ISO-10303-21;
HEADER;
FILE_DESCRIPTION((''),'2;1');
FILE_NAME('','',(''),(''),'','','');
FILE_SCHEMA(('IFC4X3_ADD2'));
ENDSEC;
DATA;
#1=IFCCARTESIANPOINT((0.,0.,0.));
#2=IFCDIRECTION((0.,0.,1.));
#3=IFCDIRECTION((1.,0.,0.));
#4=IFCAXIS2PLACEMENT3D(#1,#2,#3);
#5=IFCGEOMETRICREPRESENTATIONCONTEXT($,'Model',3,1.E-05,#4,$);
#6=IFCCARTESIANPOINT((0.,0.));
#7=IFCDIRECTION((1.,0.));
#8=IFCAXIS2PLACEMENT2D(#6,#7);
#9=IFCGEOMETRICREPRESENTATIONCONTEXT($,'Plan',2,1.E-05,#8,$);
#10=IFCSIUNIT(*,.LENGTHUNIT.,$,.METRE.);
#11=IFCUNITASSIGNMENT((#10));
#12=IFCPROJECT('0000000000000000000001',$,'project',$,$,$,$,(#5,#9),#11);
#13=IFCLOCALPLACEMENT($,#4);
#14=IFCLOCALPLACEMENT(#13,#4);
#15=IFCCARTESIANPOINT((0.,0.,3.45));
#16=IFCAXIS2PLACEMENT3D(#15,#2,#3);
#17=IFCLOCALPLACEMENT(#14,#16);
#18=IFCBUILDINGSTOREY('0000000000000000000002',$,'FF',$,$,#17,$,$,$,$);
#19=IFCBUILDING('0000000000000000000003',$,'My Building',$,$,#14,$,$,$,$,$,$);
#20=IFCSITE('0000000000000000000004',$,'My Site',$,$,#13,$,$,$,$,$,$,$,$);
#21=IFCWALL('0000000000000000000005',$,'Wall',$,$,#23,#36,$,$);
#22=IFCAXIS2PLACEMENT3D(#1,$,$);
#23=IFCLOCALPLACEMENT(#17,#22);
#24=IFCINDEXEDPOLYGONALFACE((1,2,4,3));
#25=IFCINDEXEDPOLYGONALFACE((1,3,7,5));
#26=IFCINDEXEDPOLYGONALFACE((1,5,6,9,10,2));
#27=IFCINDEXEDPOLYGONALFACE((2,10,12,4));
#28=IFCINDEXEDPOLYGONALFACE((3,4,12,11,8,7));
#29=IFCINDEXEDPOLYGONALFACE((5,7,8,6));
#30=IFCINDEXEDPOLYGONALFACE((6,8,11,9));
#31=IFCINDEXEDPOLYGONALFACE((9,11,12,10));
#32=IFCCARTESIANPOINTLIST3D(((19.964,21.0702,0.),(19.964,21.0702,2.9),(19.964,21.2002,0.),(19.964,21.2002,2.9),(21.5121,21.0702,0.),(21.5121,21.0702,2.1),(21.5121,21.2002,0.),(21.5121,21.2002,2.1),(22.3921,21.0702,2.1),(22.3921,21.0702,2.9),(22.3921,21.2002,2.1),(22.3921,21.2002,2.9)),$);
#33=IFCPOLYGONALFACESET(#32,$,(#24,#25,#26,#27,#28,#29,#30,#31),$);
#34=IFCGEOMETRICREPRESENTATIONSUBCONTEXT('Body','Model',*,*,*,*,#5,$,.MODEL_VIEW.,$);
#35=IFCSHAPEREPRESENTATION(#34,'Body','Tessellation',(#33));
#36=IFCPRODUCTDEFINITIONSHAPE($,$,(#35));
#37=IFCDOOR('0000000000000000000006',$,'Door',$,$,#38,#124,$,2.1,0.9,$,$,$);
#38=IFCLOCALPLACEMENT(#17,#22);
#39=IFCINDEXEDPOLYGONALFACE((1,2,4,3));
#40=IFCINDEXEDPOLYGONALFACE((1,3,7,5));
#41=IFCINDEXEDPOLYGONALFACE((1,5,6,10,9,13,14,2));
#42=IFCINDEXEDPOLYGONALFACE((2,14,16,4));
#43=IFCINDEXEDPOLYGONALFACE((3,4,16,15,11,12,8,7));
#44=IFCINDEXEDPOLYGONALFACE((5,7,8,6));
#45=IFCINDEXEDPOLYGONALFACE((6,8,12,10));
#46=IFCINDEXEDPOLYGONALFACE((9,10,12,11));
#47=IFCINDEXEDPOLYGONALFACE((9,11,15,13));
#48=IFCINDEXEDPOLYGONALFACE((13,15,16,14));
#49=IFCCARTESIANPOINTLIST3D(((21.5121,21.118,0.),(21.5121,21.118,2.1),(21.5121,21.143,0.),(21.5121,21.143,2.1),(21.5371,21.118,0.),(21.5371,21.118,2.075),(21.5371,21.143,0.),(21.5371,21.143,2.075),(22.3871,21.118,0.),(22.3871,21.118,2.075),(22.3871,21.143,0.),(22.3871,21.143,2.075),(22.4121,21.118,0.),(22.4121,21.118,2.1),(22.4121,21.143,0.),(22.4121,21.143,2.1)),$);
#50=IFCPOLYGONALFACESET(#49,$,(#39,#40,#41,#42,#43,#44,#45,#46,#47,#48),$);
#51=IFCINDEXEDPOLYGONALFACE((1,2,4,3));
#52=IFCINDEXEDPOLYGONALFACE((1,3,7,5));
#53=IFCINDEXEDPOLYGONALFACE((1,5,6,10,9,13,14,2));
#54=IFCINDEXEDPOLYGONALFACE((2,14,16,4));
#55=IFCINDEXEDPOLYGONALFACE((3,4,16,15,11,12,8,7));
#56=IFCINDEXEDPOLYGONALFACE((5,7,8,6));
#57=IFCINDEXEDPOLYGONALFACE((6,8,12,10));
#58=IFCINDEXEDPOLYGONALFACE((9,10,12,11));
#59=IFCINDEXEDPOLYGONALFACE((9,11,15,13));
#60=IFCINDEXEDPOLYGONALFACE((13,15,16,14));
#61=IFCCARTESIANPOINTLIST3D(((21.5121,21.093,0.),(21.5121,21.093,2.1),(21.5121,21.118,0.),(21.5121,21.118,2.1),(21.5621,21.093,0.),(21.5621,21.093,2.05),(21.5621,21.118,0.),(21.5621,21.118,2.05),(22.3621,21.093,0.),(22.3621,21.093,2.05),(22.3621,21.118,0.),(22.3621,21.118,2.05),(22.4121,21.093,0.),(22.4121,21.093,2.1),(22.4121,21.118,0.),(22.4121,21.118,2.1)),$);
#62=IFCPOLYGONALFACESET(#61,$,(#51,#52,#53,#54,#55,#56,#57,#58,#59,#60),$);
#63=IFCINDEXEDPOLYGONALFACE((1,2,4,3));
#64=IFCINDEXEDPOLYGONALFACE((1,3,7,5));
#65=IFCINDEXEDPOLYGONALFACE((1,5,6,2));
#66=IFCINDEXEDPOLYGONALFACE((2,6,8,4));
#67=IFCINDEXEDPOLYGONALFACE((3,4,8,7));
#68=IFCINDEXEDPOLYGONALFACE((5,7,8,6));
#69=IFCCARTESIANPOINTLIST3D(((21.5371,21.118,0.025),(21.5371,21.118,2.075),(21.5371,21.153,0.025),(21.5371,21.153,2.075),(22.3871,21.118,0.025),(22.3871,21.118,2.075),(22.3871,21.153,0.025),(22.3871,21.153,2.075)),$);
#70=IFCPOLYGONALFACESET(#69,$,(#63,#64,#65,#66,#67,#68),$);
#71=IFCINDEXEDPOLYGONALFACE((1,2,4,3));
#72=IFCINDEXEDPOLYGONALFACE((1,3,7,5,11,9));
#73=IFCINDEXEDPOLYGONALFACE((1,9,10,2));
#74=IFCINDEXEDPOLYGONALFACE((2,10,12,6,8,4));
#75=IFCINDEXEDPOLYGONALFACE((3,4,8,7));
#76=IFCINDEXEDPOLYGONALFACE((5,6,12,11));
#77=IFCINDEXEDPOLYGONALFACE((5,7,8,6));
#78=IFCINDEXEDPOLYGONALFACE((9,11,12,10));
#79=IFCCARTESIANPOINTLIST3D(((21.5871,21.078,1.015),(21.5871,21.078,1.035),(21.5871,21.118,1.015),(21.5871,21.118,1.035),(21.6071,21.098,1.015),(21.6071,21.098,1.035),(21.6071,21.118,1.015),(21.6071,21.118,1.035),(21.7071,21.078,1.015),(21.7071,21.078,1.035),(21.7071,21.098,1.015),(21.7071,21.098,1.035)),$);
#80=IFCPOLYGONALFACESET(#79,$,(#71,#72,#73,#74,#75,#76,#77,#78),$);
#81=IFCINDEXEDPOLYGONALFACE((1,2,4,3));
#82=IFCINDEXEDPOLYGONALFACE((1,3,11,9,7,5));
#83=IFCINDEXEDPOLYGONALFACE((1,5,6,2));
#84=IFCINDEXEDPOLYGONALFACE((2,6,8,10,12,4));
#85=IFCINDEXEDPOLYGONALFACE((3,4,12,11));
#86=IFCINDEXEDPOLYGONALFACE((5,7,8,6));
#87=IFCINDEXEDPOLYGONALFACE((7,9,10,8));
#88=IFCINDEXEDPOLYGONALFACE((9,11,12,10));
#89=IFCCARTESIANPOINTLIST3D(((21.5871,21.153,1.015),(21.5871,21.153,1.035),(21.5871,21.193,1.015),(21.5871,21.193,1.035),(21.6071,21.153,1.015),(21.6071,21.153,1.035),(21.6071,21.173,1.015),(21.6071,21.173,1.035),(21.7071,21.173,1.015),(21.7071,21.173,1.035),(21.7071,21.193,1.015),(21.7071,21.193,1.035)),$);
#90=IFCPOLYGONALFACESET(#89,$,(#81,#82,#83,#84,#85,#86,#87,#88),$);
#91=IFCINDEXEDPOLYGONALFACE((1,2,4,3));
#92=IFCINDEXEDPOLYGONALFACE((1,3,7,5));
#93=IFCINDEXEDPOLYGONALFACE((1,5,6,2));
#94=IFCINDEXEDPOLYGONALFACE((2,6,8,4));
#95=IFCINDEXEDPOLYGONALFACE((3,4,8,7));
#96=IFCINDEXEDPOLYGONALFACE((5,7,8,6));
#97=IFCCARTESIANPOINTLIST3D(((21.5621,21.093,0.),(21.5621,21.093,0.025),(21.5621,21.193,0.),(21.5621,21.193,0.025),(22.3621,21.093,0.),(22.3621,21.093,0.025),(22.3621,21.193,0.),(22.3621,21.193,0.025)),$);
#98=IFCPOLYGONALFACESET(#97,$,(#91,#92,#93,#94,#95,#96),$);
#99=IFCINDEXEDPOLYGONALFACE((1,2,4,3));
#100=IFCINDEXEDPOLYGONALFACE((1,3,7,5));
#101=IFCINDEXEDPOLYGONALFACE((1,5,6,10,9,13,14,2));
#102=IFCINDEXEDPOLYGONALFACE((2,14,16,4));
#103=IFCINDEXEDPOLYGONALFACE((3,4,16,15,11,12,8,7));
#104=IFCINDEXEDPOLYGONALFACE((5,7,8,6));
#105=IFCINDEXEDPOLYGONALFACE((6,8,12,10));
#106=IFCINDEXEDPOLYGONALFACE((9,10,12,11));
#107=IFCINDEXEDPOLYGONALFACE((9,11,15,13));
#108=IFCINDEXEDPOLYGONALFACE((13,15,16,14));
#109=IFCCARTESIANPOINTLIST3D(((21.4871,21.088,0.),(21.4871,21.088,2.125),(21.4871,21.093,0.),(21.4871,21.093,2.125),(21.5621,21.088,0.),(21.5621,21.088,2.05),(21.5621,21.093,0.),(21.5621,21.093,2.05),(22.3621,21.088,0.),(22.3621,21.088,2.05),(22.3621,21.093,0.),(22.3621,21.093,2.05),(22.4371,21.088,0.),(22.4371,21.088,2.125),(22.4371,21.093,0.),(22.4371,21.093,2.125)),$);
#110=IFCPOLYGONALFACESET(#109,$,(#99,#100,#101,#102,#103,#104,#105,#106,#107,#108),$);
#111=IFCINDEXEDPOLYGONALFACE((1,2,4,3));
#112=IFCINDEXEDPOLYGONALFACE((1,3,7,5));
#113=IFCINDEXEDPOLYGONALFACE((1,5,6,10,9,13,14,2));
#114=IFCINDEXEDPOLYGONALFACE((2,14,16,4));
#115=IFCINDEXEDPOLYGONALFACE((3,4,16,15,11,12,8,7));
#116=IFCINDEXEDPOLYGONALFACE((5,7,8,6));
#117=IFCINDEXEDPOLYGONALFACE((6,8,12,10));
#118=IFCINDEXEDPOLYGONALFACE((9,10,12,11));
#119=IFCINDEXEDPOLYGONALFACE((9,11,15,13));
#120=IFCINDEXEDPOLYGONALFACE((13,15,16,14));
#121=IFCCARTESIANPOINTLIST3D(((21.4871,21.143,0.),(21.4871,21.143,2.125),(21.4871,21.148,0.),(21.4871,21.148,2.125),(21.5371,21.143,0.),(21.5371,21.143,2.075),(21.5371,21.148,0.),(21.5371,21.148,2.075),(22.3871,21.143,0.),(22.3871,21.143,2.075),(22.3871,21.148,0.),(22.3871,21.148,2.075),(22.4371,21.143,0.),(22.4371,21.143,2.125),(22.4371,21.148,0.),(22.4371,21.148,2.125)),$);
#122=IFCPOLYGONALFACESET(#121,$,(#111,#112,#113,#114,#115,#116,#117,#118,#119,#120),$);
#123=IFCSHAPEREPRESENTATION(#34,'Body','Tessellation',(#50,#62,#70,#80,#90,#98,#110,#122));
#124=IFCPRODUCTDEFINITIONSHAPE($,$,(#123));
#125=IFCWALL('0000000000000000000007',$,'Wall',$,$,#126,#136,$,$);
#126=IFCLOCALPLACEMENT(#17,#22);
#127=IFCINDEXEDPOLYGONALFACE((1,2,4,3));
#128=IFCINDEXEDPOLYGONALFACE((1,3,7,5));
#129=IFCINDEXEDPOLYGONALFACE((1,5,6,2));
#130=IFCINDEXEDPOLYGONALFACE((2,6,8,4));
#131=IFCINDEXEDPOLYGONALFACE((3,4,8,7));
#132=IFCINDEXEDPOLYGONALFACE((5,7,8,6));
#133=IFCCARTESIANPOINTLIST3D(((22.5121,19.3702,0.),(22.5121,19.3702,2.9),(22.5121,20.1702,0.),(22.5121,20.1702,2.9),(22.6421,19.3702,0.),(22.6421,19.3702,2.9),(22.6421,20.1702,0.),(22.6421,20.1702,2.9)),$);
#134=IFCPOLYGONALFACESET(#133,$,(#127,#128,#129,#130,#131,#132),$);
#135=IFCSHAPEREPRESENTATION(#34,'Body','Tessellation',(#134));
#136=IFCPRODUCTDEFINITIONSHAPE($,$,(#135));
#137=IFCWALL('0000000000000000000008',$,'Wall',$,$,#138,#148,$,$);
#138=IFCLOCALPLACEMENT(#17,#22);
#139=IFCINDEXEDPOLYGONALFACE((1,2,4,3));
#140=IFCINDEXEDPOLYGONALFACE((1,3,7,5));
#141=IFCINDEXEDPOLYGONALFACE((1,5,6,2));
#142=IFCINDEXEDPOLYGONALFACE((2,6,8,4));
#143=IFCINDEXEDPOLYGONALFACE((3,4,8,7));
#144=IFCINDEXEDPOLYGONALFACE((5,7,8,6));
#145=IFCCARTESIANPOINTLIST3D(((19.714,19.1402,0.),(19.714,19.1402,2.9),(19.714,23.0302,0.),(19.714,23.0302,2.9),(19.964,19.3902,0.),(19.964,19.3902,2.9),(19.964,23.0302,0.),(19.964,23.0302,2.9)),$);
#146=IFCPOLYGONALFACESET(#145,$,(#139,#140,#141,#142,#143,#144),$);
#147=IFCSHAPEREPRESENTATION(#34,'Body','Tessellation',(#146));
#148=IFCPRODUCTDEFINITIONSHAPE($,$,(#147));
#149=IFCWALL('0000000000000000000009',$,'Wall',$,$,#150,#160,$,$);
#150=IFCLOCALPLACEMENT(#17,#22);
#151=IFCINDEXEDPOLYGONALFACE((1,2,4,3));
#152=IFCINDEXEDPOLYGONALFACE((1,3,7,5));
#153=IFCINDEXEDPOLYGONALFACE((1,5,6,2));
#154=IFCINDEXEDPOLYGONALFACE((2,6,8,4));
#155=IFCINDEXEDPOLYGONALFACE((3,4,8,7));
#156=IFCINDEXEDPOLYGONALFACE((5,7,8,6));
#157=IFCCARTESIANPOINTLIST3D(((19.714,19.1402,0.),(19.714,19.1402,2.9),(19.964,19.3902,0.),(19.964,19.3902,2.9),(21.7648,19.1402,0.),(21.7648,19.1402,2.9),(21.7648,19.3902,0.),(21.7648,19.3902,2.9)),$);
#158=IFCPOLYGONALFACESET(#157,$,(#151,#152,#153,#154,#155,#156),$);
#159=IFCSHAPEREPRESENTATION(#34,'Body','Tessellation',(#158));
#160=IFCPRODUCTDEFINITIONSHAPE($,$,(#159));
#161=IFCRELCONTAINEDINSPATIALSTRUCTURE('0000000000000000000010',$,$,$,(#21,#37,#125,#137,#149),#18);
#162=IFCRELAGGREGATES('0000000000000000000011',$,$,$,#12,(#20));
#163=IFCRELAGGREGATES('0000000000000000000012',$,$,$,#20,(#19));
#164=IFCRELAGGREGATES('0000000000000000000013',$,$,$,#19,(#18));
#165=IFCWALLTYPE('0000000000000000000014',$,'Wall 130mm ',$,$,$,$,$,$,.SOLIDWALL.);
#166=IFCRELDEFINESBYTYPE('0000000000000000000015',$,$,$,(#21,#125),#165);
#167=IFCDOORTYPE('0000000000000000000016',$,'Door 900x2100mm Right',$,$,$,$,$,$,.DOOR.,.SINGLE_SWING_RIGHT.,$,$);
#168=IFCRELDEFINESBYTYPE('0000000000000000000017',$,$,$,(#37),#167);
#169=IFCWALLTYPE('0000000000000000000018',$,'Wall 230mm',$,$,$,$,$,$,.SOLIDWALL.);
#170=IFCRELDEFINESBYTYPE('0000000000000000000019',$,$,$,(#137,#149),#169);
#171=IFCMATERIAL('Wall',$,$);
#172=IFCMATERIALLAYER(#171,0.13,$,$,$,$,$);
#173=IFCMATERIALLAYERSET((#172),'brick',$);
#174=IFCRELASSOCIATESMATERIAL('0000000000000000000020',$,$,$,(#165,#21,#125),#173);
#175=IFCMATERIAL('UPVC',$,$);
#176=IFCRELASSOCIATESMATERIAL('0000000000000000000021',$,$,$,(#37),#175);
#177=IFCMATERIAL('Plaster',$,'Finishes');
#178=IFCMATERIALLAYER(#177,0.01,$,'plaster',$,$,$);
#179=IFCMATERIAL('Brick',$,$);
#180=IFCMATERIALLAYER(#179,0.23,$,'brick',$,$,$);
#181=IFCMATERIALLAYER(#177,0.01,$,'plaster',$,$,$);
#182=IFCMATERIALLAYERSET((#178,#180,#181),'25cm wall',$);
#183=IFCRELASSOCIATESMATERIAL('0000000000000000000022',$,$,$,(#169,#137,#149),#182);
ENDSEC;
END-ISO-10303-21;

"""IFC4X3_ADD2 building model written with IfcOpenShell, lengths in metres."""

from ifc_helpers import new_model, entity, si_unit, frame, origin_with_axes, origin_2d_with_axis, place, context, subcontext, project, spatial, line, indexed_curve, outline, extrude, shape, source, transform, mapped, material, layer, layer_set, layer_usage, type_object, type_shapes, element, fill, save


model = new_model("IFC4X3_ADD2")

# Units and contexts
model_context = context("Model", 3, precision=1e-05, world=origin_with_axes())
plan_context = context("Plan", 2, precision=1e-05, world=origin_2d_with_axis())
body_context_1 = subcontext(model_context, "Body", "Model", "MODEL_VIEW")
body_context_2 = subcontext(plan_context, "Body", "Plan", "PLAN_VIEW")
ifc_project = project(units=[si_unit("LENGTHUNIT", "METRE")], contexts=[model_context, plan_context])

# Site, building, storey
site_placement = place(None, origin_with_axes())
site = spatial("IfcSite", under=ifc_project, at=site_placement, Name="My Site")
building_placement = place(site_placement, origin_with_axes())
building = spatial("IfcBuilding", under=site, at=building_placement, Name="My Building")
storey_placement = place(building_placement, frame((0.0, 0.0, 3.45), z_axis=(0.0, 0.0, 1.0), x_axis=(1.0, 0.0, 0.0)))
storey = spatial("IfcBuildingStorey", under=building, at=storey_placement, Name="FF")

# Shared definitions
ifc_material_1 = material(Name="UPVC")

# Wall, opening, door
ifc_material_2 = material(Name="Wall")
ifc_layer_1 = layer(ifc_material_2, 0.13)
ifc_layer_set_1 = layer_set([ifc_layer_1], Name="brick")
ifc_layer_usage_1 = layer_usage(ifc_layer_set_1, "AXIS2", "POSITIVE", 0.0)
wall_type_1 = type_object("IfcWallType", Name="Wall 130mm ", PredefinedType="SOLIDWALL", material=ifc_layer_set_1)
wall_1_placement = place(storey_placement, frame((22.6421, 21.2002, 0.0), z_axis=(0.0, 0.0, 1.0), x_axis=(-1.0, 0.0, 0.0)))
wall_1 = element("IfcWall", 1, at=wall_1_placement, inside=storey, type_object=wall_type_1, material=ifc_layer_usage_1, Name="Wall", context=body_context_1, shape_type="SweptSolid", body=[
    extrude(outline(indexed_curve([(0.25, 0.0), (0.25, 0.13), (2.6781, 0.13), (2.6781, 0.0)], segments=[line(1, 2, 3, 4, 1)])), origin_with_axes(), (0.0, 0.0, 1.0), 2.9),
])
shared_shape_1 = source(origin_with_axes(), body_context_1, "Body", "SweptSolid", [
    extrude(outline(indexed_curve([(0.0, 0.0), (0.9, 0.0), (0.9, 2.1), (0.0, 2.1)], segments=[line(1, 2, 3, 4, 1)])), frame((0.0, -0.6, 0.0), z_axis=(0.0, -1.0, 0.0), x_axis=(1.0, 0.0, 0.0)), (0.0, 0.0, -1.0), 1.2),
])
opening_placement = place(wall_1_placement, frame((1.13, 0.1072, 0.0), z_axis=(0.0, 0.0, 1.0), x_axis=(-1.0, 0.0, 0.0)))
opening = element("IfcOpeningElement", 2, at=opening_placement, cuts=wall_1, PredefinedType="OPENING", context=body_context_1, shape_type="MappedRepresentation", body=[
    mapped(shared_shape_1, transform((0.0, 0.0, 0.0), x_axis=(1.0, 0.0, 0.0), y_axis=(0.0, 1.0, 0.0), z_axis=(0.0, 0.0, 1.0), scale=1.0)),
])
door_type = type_object("IfcDoorType", Name="Door 900x2100mm Right", OperationType="SINGLE_SWING_RIGHT", PredefinedType="DOOR")
shared_shape_2 = source(origin_with_axes(), body_context_1, "Body", "SweptSolid", [
    extrude(outline(indexed_curve([(0.0, 0.0), (0.0, 2.1), (0.9, 2.1), (0.9, 0.0), (0.875, 0.0), (0.875, 2.075), (0.025, 2.075), (0.025, 0.0)], segments=[line(1, 2, 3, 4, 5, 6, 7, 8, 1)])), frame((0.0, 0.025, 0.0), z_axis=(0.0, -1.0, 0.0), x_axis=(1.0, 0.0, 0.0)), (0.0, 0.0, -1.0), 0.025),
    extrude(outline(indexed_curve([(0.0, 0.0), (0.0, 2.1), (0.9, 2.1), (0.9, 0.0), (0.85, 0.0), (0.85, 2.05), (0.05, 2.05), (0.05, 0.0)], segments=[line(1, 2, 3, 4, 5, 6, 7, 8, 1)])), frame((0.0, 0.0, 0.0), z_axis=(0.0, -1.0, 0.0), x_axis=(1.0, 0.0, 0.0)), (0.0, 0.0, -1.0), 0.025),
    extrude(outline(indexed_curve([(0.0, 0.0), (0.85, 0.0), (0.85, 0.035), (0.0, 0.035)], segments=[line(1, 2, 3, 4, 1)])), frame((0.025, 0.025, 0.025), z_axis=(0.0, 0.0, 1.0), x_axis=(1.0, 0.0, 0.0)), (0.0, 0.0, 1.0), 2.05),
    extrude(outline(indexed_curve([(0.0, 0.0), (0.0, -0.04), (0.12, -0.04), (0.12, -0.02), (0.02, -0.02), (0.02, 0.0)], segments=[line(1, 2, 3, 4, 5, 6, 1)])), frame((0.075, 0.025, 1.015), z_axis=(0.0, 0.0, 1.0), x_axis=(1.0, 0.0, 0.0)), (0.0, 0.0, 1.0), 0.02),
    extrude(outline(indexed_curve([(0.0, 0.0), (0.0, 0.04), (0.12, 0.04), (0.12, 0.02), (0.02, 0.02), (0.02, 0.0)], segments=[line(1, 2, 3, 4, 5, 6, 1)])), frame((0.075, 0.06, 1.015), z_axis=(0.0, 0.0, 1.0), x_axis=(1.0, 0.0, 0.0)), (0.0, 0.0, 1.0), 0.02),
    extrude(outline(indexed_curve([(0.0, 0.0), (0.8, 0.0), (0.8, 0.1), (0.0, 0.1)], segments=[line(1, 2, 3, 4, 1)])), frame((0.05, 0.0, 0.0), z_axis=(0.0, 0.0, 1.0), x_axis=(1.0, 0.0, 0.0)), (0.0, 0.0, 1.0), 0.025),
    extrude(outline(indexed_curve([(0.0, 0.0), (0.0, 2.125), (0.95, 2.125), (0.95, 0.0), (0.875, 0.0), (0.875, 2.05), (0.075, 2.05), (0.075, 0.0)], segments=[line(1, 2, 3, 4, 5, 6, 7, 8, 1)])), frame((-0.025, -0.005, 0.0), z_axis=(0.0, -1.0, 0.0), x_axis=(1.0, 0.0, 0.0)), (0.0, 0.0, -1.0), 0.005),
    extrude(outline(indexed_curve([(0.0, 0.0), (0.0, 2.125), (0.95, 2.125), (0.95, 0.0), (0.9, 0.0), (0.9, 2.075), (0.05, 2.075), (0.05, 0.0)], segments=[line(1, 2, 3, 4, 5, 6, 7, 8, 1)])), frame((-0.025, 0.05, 0.0), z_axis=(0.0, -1.0, 0.0), x_axis=(1.0, 0.0, 0.0)), (0.0, 0.0, -1.0), 0.005),
])
shared_shape_3 = source(origin_with_axes(), body_context_2, "Body", "Curve2D", [
    entity("IfcIndexedPolyCurve", entity("IfcCartesianPointList2D", [[0.0, 0.0], [0.0, 0.05], [0.025, 0.05], [0.025, 0.025], [0.05, 0.025], [0.05, 0.0]]), [entity("IfcLineIndex", [1, 2, 3, 4, 5, 6, 1])]),
    entity("IfcIndexedPolyCurve", entity("IfcCartesianPointList2D", [[0.9, 0.0], [0.9, 0.05], [0.875, 0.05], [0.875, 0.025], [0.85, 0.025], [0.85, 0.0]]), [entity("IfcLineIndex", [1, 2, 3, 4, 5, 6, 1])]),
    entity("IfcTrimmedCurve", entity("IfcEllipse", entity("IfcAxis2Placement2D", entity("IfcCartesianPoint", [0.84, 0.05]), entity("IfcDirection", [1.0, 0.0])), 0.815, 0.85), [entity("IfcCartesianPoint", [0.84, 0.9])], [entity("IfcCartesianPoint", [0.025, 0.05])], True, "CARTESIAN"),
    entity("IfcIndexedPolyCurve", entity("IfcCartesianPointList2D", [[0.875, 0.05], [0.84, 0.05], [0.84, 0.9], [0.875, 0.9]]), [entity("IfcLineIndex", [1, 2, 3, 4, 1])]),
])
type_shapes(door_type, [shared_shape_2, shared_shape_3])
door_placement = place(opening_placement, frame((0.0, 0.0, 0.0), z_axis=(0.0, 0.0, 1.0), x_axis=(1.0, 0.0, 0.0)))
door = element("IfcDoor", 3, at=door_placement, inside=storey, type_object=door_type, material=ifc_material_1, Name="Door", OverallHeight=2.1, OverallWidth=0.9, shapes=[
    shape(body_context_1, "Body", "MappedRepresentation", [mapped(shared_shape_2, transform((0.0, 0.0, 0.0), x_axis=(1.0, 0.0, 0.0), y_axis=(0.0, 1.0, 0.0), z_axis=(0.0, 0.0, 1.0), scale=1.0))]),
    shape(body_context_2, "Body", "MappedRepresentation", [mapped(shared_shape_3, transform((0.0, 0.0, 0.0), x_axis=(1.0, 0.0, 0.0), y_axis=(0.0, 1.0, 0.0), z_axis=(0.0, 0.0, 1.0), scale=1.0))]),
])
fill(opening, door)

# Walls
ifc_layer_usage_2 = layer_usage(ifc_layer_set_1, "AXIS2", "POSITIVE", 0.0)
wall_2_placement = place(storey_placement, frame((22.6421, 19.3702, 0.0), z_axis=(0.0, 0.0, 1.0), x_axis=(0.000001, 1.0, 0.0)))
element("IfcWall", 4, at=wall_2_placement, inside=storey, type_object=wall_type_1, material=ifc_layer_usage_2, Name="Wall", context=body_context_1, shape_type="SweptSolid", body=[
    extrude(outline(indexed_curve([(0.0, 0.0), (0.0, 0.13), (0.8, 0.13), (0.8, 0.0), (0.0, 0.0)], self_intersect=False)), origin_with_axes(), (0.0, 0.0, 1.0), 2.9),
])
ifc_material_3 = material(Name="Plaster", Category="Finishes")
ifc_layer_2 = layer(ifc_material_3, 0.01, Name="plaster")
ifc_material_4 = material(Name="Brick")
ifc_layer_3 = layer(ifc_material_4, 0.23, Name="brick")
ifc_layer_4 = layer(ifc_material_3, 0.01, Name="plaster")
ifc_layer_set_2 = layer_set([ifc_layer_2, ifc_layer_3, ifc_layer_4], Name="25cm wall")
ifc_layer_usage_3 = layer_usage(ifc_layer_set_2, "AXIS2", "NEGATIVE", 0.0)
wall_type_2 = type_object("IfcWallType", Name="Wall 230mm", PredefinedType="SOLIDWALL", material=ifc_layer_set_2)
wall_3_placement = place(storey_placement, frame((19.714, 19.1402, 0.0), z_axis=(0.0, 0.0, 1.0), x_axis=(0.000001, 1.0, 0.0)))
element("IfcWall", 5, at=wall_3_placement, inside=storey, type_object=wall_type_2, material=ifc_layer_usage_3, Name="Wall", context=body_context_1, shape_type="SweptSolid", body=[
    extrude(outline(indexed_curve([(0.25, -0.25), (0.0, 0.0), (3.89, 0.0), (3.89, -0.25)], segments=[line(1, 2, 3, 4, 1)])), origin_with_axes(), (0.0, 0.0, 1.0), 2.9),
])
ifc_layer_usage_4 = layer_usage(ifc_layer_set_2, "AXIS2", "NEGATIVE", 0.0)
wall_4_placement = place(storey_placement, frame((21.7648, 19.1402, 0.0), z_axis=(0.0, 0.0, 1.0), x_axis=(-1.0, 0.0, 0.0)))
element("IfcWall", 6, at=wall_4_placement, inside=storey, type_object=wall_type_2, material=ifc_layer_usage_4, Name="Wall", context=body_context_1, shape_type="SweptSolid", body=[
    extrude(outline(indexed_curve([(0.0, -0.25), (0.0, 0.0), (2.0508, 0.0), (1.8008, -0.25)], segments=[line(1, 2, 3, 4, 1)])), origin_with_axes(), (0.0, 0.0, 1.0), 2.9),
])

save(model, "model.ifc")
